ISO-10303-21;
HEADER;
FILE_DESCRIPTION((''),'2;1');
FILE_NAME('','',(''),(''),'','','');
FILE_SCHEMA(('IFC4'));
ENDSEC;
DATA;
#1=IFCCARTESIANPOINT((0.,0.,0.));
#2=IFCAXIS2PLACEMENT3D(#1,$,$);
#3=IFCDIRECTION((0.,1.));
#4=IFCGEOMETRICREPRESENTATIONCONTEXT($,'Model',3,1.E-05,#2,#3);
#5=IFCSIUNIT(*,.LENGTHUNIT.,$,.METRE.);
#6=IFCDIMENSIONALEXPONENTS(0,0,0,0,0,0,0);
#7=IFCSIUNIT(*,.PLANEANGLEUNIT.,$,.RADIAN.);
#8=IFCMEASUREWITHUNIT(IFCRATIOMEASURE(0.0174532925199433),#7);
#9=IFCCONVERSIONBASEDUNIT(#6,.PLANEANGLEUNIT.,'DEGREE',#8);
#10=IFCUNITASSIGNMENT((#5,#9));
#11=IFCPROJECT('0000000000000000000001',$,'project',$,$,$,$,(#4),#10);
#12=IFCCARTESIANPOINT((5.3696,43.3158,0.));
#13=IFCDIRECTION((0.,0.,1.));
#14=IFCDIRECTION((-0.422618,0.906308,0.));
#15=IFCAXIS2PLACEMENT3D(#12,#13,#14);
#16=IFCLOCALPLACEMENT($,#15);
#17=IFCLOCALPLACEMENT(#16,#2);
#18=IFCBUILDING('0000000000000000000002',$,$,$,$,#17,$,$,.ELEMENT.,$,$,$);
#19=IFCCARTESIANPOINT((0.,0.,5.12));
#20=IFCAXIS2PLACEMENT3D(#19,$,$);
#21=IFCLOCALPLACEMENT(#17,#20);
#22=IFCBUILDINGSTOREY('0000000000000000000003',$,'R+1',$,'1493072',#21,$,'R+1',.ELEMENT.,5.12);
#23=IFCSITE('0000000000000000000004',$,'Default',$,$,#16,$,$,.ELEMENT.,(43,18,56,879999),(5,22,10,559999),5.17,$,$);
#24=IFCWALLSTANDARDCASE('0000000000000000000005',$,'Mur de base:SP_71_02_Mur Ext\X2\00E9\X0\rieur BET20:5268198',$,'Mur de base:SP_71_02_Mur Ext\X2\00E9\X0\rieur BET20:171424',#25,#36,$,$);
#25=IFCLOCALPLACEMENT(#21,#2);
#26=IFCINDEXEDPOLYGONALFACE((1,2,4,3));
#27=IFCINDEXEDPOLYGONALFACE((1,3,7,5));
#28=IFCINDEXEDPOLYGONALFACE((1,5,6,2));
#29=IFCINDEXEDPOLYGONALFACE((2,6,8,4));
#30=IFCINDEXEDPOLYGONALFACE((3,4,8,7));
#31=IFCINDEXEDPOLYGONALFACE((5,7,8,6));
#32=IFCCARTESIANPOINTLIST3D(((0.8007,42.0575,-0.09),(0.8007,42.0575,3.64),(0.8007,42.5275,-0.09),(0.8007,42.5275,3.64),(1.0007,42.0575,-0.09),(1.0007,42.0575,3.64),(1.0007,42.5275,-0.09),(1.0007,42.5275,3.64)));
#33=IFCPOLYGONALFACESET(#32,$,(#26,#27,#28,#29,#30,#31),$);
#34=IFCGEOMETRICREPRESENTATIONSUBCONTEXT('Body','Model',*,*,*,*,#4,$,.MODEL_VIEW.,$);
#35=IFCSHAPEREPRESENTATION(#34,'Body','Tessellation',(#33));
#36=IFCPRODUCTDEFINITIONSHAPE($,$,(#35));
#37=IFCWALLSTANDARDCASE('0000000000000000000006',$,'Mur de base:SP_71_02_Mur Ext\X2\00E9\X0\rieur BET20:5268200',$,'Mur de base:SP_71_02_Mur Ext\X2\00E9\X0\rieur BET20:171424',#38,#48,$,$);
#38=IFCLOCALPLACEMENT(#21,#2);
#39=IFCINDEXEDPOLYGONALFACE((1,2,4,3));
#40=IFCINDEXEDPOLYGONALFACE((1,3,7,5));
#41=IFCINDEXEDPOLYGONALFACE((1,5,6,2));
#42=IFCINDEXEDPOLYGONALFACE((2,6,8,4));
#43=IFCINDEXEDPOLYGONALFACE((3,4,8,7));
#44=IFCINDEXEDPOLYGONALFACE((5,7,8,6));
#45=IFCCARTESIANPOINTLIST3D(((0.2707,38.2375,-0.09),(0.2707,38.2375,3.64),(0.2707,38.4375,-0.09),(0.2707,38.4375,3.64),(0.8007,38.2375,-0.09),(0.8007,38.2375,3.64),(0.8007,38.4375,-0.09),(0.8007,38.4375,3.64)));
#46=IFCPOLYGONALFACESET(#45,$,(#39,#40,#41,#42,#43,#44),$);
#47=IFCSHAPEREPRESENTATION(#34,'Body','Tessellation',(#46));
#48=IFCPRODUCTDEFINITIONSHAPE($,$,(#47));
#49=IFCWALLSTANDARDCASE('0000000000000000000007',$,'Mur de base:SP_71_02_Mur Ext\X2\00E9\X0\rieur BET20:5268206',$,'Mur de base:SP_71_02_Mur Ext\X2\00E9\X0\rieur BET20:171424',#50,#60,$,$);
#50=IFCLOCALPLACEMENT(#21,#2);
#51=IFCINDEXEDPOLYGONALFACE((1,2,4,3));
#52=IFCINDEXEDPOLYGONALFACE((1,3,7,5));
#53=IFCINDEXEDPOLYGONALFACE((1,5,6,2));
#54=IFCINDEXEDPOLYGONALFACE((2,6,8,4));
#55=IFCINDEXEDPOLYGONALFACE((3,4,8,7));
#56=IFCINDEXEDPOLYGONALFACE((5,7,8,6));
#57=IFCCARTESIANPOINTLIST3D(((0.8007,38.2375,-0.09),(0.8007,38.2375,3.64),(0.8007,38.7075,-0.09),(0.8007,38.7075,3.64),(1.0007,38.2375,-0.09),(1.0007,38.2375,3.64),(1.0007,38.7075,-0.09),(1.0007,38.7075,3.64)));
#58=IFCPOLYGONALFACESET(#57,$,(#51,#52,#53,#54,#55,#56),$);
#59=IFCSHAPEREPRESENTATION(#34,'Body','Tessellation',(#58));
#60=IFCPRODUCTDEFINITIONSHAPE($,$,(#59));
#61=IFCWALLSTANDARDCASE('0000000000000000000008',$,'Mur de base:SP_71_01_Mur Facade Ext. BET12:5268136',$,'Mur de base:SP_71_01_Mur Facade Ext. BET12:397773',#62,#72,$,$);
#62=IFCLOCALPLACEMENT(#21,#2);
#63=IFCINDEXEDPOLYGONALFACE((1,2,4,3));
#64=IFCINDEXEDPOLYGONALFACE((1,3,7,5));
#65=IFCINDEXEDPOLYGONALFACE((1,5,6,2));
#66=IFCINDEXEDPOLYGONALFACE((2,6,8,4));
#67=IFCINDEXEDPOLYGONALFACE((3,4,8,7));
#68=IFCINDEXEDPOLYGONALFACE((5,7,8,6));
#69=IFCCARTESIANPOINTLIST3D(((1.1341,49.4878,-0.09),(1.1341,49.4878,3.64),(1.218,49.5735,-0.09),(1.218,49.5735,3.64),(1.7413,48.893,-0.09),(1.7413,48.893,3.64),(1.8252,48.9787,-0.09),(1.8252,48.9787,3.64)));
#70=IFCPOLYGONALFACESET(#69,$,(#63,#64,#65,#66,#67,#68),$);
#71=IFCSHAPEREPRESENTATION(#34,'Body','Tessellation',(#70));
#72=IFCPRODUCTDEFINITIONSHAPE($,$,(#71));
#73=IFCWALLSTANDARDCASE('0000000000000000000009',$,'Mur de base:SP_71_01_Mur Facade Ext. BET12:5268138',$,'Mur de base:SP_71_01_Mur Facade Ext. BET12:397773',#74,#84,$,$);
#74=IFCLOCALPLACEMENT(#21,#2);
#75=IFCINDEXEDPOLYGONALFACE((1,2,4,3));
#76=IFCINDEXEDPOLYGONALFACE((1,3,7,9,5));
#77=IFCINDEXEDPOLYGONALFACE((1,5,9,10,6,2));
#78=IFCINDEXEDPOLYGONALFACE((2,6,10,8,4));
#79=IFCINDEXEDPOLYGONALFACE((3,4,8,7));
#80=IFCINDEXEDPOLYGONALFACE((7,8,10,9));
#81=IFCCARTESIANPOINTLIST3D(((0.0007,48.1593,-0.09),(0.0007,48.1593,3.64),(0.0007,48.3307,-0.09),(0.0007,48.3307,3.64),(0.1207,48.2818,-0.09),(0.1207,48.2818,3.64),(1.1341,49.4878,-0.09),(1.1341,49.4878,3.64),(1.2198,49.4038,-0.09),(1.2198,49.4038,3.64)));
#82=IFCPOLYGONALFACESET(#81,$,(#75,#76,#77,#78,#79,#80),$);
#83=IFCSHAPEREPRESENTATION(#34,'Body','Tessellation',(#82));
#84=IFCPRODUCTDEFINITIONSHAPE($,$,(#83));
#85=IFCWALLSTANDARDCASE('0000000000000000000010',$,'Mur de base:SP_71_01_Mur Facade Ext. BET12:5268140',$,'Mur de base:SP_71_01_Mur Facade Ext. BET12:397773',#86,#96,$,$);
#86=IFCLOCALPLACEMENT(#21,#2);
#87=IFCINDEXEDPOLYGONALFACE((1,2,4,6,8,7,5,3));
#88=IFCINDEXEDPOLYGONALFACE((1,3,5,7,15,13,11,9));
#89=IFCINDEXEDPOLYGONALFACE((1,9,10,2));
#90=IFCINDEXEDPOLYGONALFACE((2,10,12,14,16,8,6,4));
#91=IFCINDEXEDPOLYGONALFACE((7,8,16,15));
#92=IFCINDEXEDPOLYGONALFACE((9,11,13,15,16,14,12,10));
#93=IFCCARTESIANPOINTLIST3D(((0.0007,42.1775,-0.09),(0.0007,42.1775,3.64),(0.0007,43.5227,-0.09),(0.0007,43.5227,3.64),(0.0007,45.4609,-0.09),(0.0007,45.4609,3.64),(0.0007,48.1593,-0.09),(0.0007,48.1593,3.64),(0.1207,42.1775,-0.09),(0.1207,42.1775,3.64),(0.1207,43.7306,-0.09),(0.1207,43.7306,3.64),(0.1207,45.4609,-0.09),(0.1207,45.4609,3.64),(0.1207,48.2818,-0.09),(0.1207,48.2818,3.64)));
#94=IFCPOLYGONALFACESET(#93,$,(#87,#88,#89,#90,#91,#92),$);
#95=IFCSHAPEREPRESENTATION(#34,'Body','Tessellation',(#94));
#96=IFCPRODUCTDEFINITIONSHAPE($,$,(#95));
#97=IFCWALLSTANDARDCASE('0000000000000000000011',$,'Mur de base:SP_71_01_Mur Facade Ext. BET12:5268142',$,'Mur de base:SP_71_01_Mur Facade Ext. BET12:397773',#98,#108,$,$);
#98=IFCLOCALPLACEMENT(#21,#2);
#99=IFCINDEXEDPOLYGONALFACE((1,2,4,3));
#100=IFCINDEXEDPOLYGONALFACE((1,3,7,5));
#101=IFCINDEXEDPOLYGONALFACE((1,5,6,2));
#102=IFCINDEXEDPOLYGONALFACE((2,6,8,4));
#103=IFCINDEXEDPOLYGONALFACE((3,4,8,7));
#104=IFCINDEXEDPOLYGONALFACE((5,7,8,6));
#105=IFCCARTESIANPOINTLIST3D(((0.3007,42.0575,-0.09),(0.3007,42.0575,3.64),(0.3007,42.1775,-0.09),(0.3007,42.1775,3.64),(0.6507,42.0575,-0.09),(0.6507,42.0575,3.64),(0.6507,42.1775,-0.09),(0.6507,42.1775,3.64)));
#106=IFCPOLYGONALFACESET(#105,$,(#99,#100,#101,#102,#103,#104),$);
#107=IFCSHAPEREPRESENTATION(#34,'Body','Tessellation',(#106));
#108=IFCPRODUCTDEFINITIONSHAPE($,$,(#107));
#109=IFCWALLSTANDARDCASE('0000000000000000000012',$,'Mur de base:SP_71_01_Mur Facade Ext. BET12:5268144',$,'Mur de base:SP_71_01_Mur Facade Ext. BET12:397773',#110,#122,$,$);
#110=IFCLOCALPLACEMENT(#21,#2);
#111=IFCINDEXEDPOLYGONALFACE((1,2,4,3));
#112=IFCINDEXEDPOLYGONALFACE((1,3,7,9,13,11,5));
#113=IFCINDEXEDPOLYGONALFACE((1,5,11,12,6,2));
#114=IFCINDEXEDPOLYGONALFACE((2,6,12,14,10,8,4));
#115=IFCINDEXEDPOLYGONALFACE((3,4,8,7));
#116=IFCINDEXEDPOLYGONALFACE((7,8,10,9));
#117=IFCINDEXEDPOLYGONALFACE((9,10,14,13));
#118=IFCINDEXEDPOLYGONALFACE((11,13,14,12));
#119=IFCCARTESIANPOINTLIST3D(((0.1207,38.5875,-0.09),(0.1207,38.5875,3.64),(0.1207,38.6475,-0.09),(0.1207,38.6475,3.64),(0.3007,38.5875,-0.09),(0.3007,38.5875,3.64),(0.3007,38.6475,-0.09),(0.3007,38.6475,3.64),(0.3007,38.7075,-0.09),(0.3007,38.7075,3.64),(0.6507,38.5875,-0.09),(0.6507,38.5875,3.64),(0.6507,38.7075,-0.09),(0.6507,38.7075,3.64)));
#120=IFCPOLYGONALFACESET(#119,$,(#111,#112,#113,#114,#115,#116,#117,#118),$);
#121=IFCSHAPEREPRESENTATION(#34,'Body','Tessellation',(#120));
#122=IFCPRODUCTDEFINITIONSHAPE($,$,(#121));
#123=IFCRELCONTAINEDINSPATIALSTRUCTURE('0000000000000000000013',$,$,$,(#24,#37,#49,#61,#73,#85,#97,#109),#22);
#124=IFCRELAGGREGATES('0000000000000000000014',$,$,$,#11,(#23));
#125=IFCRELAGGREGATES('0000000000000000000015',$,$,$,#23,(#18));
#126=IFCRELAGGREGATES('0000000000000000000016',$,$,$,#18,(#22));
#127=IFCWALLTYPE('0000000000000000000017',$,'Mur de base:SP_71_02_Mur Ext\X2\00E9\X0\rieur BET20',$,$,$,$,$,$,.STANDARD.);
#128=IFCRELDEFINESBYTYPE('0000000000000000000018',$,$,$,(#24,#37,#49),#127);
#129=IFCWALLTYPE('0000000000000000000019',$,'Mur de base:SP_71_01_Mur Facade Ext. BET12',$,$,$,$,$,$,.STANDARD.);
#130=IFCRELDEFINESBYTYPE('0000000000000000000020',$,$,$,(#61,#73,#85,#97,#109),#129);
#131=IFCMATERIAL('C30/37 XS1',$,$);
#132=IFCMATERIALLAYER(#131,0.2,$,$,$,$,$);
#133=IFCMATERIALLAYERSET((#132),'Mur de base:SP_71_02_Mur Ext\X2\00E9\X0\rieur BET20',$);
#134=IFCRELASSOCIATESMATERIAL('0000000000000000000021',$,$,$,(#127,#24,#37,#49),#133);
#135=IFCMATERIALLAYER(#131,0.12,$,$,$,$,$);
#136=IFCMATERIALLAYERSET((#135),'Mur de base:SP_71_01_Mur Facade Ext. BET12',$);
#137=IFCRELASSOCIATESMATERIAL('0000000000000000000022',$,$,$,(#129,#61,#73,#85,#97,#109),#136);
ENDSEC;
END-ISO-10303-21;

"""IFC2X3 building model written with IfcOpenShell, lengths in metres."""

from ifc_helpers import new_model, entity, si_unit, converted_unit, direction, frame, frame_2d, origin, place, context, subcontext, project, spatial, polyline, rectangle, outline, extrude, material, layer, layer_set, layer_usage, type_object, element, save


model = new_model("IFC2X3")

# Units and contexts
model_context = context("Model", 3, precision=1e-05, world=origin(), true_north=direction((0.0, 1.0)))
body_context = subcontext(model_context, "Body", "Model", "MODEL_VIEW")
ifc_project = project(units=[si_unit("LENGTHUNIT", "METRE"), converted_unit("PLANEANGLEUNIT", "DEGREE", entity("IfcRatioMeasure", 0.0174532925199433), si_unit("PLANEANGLEUNIT", "RADIAN"), dimensions=[0, 0, 0, 0, 0, 0, 0])], contexts=[model_context])

# Site, building, storey
site_placement = place(None, frame((5.3696, 43.3158, 0.0), z_axis=(0.0, 0.0, 1.0), x_axis=(-0.422618, 0.906308, 0.0)))
site = spatial("IfcSite", under=ifc_project, at=site_placement, Name="Default", CompositionType="ELEMENT", RefLatitude=(43, 18, 56, 879999), RefLongitude=(5, 22, 10, 559999), RefElevation=5.17)
building_placement = place(site_placement, origin())
building = spatial("IfcBuilding", under=site, at=building_placement, CompositionType="ELEMENT")
storey_placement = place(building_placement, frame((0.0, 0.0, 5.12)))
storey = spatial("IfcBuildingStorey", under=building, at=storey_placement, Name="R+1", ObjectType="1493072", LongName="R+1", CompositionType="ELEMENT", Elevation=5.12)

# Shared definitions
ifc_material_1 = material(Name="C30/37 XS1")

# Shared definitions
ifc_layer_1 = layer(ifc_material_1, 0.2)
ifc_layer_set_1 = layer_set([ifc_layer_1], Name="Mur de base:SP_71_02_Mur Extérieur BET20")
wall_type_1 = type_object("IfcWallType", Name="Mur de base:SP_71_02_Mur Extérieur BET20", PredefinedType="STANDARD", material=ifc_layer_set_1)

# Walls
ifc_layer_usage_1 = layer_usage(ifc_layer_set_1, "AXIS2", "NEGATIVE", 0.1)
wall_1_placement = place(storey_placement, frame((0.9007, 42.5275, -0.09), z_axis=(0.0, 0.0, 1.0), x_axis=(0.0, -1.0, 0.0)))
element("IfcWallStandardCase", 1, at=wall_1_placement, inside=storey, type_object=wall_type_1, material=ifc_layer_usage_1, Name="Mur de base:SP_71_02_Mur Extérieur BET20:5268198", ObjectType="Mur de base:SP_71_02_Mur Extérieur BET20:171424", context=body_context, shape_type="SweptSolid", body=[
    extrude(rectangle(XDim=0.47, YDim=0.2, at=frame_2d((0.235, 0.0), x_axis=(-1.0, 0.0))), origin(), (0.0, 0.0, 1.0), 3.73),
])
ifc_layer_usage_2 = layer_usage(ifc_layer_set_1, "AXIS2", "NEGATIVE", 0.1)
wall_2_placement = place(storey_placement, frame((0.2707, 38.3375, -0.09)))
element("IfcWallStandardCase", 2, at=wall_2_placement, inside=storey, type_object=wall_type_1, material=ifc_layer_usage_2, Name="Mur de base:SP_71_02_Mur Extérieur BET20:5268200", ObjectType="Mur de base:SP_71_02_Mur Extérieur BET20:171424", context=body_context, shape_type="SweptSolid", body=[
    extrude(rectangle(XDim=0.53, YDim=0.2, at=frame_2d((0.265, 0.0), x_axis=(-1.0, 0.0))), origin(), (0.0, 0.0, 1.0), 3.73),
])
ifc_layer_usage_3 = layer_usage(ifc_layer_set_1, "AXIS2", "NEGATIVE", 0.1)
wall_3_placement = place(storey_placement, frame((0.9007, 38.7075, -0.09), z_axis=(0.0, 0.0, 1.0), x_axis=(0.0, -1.0, 0.0)))
element("IfcWallStandardCase", 3, at=wall_3_placement, inside=storey, type_object=wall_type_1, material=ifc_layer_usage_3, Name="Mur de base:SP_71_02_Mur Extérieur BET20:5268206", ObjectType="Mur de base:SP_71_02_Mur Extérieur BET20:171424", context=body_context, shape_type="SweptSolid", body=[
    extrude(rectangle(XDim=0.47, YDim=0.2, at=frame_2d((0.235, 0.0), x_axis=(-1.0, 0.0))), origin(), (0.0, 0.0, 1.0), 3.73),
])
ifc_layer_2 = layer(ifc_material_1, 0.12)
ifc_layer_set_2 = layer_set([ifc_layer_2], Name="Mur de base:SP_71_01_Mur Facade Ext. BET12")
ifc_layer_usage_4 = layer_usage(ifc_layer_set_2, "AXIS2", "NEGATIVE", 0.06)
wall_type_2 = type_object("IfcWallType", Name="Mur de base:SP_71_01_Mur Facade Ext. BET12", PredefinedType="STANDARD", material=ifc_layer_set_2)
wall_4_placement = place(storey_placement, frame((1.7833, 48.9358, -0.09), z_axis=(0.0, 0.0, 1.0), x_axis=(-0.714364, 0.699774, 0.0)))
element("IfcWallStandardCase", 4, at=wall_4_placement, inside=storey, type_object=wall_type_2, material=ifc_layer_usage_4, Name="Mur de base:SP_71_01_Mur Facade Ext. BET12:5268136", ObjectType="Mur de base:SP_71_01_Mur Facade Ext. BET12:397773", context=body_context, shape_type="SweptSolid", body=[
    extrude(rectangle(XDim=0.85, YDim=0.12, at=frame_2d((0.425, 0.0), x_axis=(-1.0, 0.0))), origin(), (0.0, 0.0, 1.0), 3.73),
])
ifc_layer_usage_5 = layer_usage(ifc_layer_set_2, "AXIS2", "NEGATIVE", 0.06)
wall_5_placement = place(storey_placement, frame((-0.0422, 48.2012, -0.09), z_axis=(0.0, 0.0, 1.0), x_axis=(0.699774, 0.714364, 0.0)))
element("IfcWallStandardCase", 5, at=wall_5_placement, inside=storey, type_object=wall_type_2, material=ifc_layer_usage_5, Name="Mur de base:SP_71_01_Mur Facade Ext. BET12:5268138", ObjectType="Mur de base:SP_71_01_Mur Facade Ext. BET12:397773", context=body_context, shape_type="SweptSolid", body=[
    extrude(outline(polyline([(1.7422, -0.06), (1.7422, 0.06), (0.1225, 0.06), (0.0, -0.06), (0.1715, -0.06), (1.7422, -0.06)])), origin(), (0.0, 0.0, 1.0), 3.73),
])
ifc_layer_usage_6 = layer_usage(ifc_layer_set_2, "AXIS2", "NEGATIVE", 0.06)
wall_6_placement = place(storey_placement, frame((0.0607, 42.1775, -0.09), z_axis=(0.0, 0.0, 1.0), x_axis=(0.0, 1.0, 0.0)))
element("IfcWallStandardCase", 6, at=wall_6_placement, inside=storey, type_object=wall_type_2, material=ifc_layer_usage_6, Name="Mur de base:SP_71_01_Mur Facade Ext. BET12:5268140", ObjectType="Mur de base:SP_71_01_Mur Facade Ext. BET12:397773", context=body_context, shape_type="SweptSolid", body=[
    extrude(outline(polyline([(6.1042, -0.06), (5.9817, 0.06), (3.2833, 0.06), (1.3452, 0.06), (0.0, 0.06), (0.0, -0.06), (1.553, -0.06), (3.2833, -0.06), (6.1042, -0.06)])), origin(), (0.0, 0.0, 1.0), 3.73),
])
ifc_layer_usage_7 = layer_usage(ifc_layer_set_2, "AXIS2", "NEGATIVE", 0.06)
wall_7_placement = place(storey_placement, frame((0.3007, 42.1175, -0.09)))
element("IfcWallStandardCase", 7, at=wall_7_placement, inside=storey, type_object=wall_type_2, material=ifc_layer_usage_7, Name="Mur de base:SP_71_01_Mur Facade Ext. BET12:5268142", ObjectType="Mur de base:SP_71_01_Mur Facade Ext. BET12:397773", context=body_context, shape_type="SweptSolid", body=[
    extrude(rectangle(XDim=0.35, YDim=0.12, at=frame_2d((0.175, 0.0), x_axis=(-1.0, 0.0))), origin(), (0.0, 0.0, 1.0), 3.73),
])
ifc_layer_usage_8 = layer_usage(ifc_layer_set_2, "AXIS2", "NEGATIVE", 0.06)
wall_8_placement = place(storey_placement, frame((0.6507, 38.6475, -0.09), z_axis=(0.0, 0.0, 1.0), x_axis=(-1.0, 0.0, 0.0)))
element("IfcWallStandardCase", 8, at=wall_8_placement, inside=storey, type_object=wall_type_2, material=ifc_layer_usage_8, Name="Mur de base:SP_71_01_Mur Facade Ext. BET12:5268144", ObjectType="Mur de base:SP_71_01_Mur Facade Ext. BET12:397773", context=body_context, shape_type="SweptSolid", body=[
    extrude(outline(polyline([(0.35, -0.06), (0.35, 0.0), (0.53, 0.0), (0.53, 0.06), (0.35, 0.06), (0.0, 0.06), (0.0, -0.06), (0.35, -0.06)])), origin(), (0.0, 0.0, 1.0), 3.73),
])

save(model, "model.ifc")
